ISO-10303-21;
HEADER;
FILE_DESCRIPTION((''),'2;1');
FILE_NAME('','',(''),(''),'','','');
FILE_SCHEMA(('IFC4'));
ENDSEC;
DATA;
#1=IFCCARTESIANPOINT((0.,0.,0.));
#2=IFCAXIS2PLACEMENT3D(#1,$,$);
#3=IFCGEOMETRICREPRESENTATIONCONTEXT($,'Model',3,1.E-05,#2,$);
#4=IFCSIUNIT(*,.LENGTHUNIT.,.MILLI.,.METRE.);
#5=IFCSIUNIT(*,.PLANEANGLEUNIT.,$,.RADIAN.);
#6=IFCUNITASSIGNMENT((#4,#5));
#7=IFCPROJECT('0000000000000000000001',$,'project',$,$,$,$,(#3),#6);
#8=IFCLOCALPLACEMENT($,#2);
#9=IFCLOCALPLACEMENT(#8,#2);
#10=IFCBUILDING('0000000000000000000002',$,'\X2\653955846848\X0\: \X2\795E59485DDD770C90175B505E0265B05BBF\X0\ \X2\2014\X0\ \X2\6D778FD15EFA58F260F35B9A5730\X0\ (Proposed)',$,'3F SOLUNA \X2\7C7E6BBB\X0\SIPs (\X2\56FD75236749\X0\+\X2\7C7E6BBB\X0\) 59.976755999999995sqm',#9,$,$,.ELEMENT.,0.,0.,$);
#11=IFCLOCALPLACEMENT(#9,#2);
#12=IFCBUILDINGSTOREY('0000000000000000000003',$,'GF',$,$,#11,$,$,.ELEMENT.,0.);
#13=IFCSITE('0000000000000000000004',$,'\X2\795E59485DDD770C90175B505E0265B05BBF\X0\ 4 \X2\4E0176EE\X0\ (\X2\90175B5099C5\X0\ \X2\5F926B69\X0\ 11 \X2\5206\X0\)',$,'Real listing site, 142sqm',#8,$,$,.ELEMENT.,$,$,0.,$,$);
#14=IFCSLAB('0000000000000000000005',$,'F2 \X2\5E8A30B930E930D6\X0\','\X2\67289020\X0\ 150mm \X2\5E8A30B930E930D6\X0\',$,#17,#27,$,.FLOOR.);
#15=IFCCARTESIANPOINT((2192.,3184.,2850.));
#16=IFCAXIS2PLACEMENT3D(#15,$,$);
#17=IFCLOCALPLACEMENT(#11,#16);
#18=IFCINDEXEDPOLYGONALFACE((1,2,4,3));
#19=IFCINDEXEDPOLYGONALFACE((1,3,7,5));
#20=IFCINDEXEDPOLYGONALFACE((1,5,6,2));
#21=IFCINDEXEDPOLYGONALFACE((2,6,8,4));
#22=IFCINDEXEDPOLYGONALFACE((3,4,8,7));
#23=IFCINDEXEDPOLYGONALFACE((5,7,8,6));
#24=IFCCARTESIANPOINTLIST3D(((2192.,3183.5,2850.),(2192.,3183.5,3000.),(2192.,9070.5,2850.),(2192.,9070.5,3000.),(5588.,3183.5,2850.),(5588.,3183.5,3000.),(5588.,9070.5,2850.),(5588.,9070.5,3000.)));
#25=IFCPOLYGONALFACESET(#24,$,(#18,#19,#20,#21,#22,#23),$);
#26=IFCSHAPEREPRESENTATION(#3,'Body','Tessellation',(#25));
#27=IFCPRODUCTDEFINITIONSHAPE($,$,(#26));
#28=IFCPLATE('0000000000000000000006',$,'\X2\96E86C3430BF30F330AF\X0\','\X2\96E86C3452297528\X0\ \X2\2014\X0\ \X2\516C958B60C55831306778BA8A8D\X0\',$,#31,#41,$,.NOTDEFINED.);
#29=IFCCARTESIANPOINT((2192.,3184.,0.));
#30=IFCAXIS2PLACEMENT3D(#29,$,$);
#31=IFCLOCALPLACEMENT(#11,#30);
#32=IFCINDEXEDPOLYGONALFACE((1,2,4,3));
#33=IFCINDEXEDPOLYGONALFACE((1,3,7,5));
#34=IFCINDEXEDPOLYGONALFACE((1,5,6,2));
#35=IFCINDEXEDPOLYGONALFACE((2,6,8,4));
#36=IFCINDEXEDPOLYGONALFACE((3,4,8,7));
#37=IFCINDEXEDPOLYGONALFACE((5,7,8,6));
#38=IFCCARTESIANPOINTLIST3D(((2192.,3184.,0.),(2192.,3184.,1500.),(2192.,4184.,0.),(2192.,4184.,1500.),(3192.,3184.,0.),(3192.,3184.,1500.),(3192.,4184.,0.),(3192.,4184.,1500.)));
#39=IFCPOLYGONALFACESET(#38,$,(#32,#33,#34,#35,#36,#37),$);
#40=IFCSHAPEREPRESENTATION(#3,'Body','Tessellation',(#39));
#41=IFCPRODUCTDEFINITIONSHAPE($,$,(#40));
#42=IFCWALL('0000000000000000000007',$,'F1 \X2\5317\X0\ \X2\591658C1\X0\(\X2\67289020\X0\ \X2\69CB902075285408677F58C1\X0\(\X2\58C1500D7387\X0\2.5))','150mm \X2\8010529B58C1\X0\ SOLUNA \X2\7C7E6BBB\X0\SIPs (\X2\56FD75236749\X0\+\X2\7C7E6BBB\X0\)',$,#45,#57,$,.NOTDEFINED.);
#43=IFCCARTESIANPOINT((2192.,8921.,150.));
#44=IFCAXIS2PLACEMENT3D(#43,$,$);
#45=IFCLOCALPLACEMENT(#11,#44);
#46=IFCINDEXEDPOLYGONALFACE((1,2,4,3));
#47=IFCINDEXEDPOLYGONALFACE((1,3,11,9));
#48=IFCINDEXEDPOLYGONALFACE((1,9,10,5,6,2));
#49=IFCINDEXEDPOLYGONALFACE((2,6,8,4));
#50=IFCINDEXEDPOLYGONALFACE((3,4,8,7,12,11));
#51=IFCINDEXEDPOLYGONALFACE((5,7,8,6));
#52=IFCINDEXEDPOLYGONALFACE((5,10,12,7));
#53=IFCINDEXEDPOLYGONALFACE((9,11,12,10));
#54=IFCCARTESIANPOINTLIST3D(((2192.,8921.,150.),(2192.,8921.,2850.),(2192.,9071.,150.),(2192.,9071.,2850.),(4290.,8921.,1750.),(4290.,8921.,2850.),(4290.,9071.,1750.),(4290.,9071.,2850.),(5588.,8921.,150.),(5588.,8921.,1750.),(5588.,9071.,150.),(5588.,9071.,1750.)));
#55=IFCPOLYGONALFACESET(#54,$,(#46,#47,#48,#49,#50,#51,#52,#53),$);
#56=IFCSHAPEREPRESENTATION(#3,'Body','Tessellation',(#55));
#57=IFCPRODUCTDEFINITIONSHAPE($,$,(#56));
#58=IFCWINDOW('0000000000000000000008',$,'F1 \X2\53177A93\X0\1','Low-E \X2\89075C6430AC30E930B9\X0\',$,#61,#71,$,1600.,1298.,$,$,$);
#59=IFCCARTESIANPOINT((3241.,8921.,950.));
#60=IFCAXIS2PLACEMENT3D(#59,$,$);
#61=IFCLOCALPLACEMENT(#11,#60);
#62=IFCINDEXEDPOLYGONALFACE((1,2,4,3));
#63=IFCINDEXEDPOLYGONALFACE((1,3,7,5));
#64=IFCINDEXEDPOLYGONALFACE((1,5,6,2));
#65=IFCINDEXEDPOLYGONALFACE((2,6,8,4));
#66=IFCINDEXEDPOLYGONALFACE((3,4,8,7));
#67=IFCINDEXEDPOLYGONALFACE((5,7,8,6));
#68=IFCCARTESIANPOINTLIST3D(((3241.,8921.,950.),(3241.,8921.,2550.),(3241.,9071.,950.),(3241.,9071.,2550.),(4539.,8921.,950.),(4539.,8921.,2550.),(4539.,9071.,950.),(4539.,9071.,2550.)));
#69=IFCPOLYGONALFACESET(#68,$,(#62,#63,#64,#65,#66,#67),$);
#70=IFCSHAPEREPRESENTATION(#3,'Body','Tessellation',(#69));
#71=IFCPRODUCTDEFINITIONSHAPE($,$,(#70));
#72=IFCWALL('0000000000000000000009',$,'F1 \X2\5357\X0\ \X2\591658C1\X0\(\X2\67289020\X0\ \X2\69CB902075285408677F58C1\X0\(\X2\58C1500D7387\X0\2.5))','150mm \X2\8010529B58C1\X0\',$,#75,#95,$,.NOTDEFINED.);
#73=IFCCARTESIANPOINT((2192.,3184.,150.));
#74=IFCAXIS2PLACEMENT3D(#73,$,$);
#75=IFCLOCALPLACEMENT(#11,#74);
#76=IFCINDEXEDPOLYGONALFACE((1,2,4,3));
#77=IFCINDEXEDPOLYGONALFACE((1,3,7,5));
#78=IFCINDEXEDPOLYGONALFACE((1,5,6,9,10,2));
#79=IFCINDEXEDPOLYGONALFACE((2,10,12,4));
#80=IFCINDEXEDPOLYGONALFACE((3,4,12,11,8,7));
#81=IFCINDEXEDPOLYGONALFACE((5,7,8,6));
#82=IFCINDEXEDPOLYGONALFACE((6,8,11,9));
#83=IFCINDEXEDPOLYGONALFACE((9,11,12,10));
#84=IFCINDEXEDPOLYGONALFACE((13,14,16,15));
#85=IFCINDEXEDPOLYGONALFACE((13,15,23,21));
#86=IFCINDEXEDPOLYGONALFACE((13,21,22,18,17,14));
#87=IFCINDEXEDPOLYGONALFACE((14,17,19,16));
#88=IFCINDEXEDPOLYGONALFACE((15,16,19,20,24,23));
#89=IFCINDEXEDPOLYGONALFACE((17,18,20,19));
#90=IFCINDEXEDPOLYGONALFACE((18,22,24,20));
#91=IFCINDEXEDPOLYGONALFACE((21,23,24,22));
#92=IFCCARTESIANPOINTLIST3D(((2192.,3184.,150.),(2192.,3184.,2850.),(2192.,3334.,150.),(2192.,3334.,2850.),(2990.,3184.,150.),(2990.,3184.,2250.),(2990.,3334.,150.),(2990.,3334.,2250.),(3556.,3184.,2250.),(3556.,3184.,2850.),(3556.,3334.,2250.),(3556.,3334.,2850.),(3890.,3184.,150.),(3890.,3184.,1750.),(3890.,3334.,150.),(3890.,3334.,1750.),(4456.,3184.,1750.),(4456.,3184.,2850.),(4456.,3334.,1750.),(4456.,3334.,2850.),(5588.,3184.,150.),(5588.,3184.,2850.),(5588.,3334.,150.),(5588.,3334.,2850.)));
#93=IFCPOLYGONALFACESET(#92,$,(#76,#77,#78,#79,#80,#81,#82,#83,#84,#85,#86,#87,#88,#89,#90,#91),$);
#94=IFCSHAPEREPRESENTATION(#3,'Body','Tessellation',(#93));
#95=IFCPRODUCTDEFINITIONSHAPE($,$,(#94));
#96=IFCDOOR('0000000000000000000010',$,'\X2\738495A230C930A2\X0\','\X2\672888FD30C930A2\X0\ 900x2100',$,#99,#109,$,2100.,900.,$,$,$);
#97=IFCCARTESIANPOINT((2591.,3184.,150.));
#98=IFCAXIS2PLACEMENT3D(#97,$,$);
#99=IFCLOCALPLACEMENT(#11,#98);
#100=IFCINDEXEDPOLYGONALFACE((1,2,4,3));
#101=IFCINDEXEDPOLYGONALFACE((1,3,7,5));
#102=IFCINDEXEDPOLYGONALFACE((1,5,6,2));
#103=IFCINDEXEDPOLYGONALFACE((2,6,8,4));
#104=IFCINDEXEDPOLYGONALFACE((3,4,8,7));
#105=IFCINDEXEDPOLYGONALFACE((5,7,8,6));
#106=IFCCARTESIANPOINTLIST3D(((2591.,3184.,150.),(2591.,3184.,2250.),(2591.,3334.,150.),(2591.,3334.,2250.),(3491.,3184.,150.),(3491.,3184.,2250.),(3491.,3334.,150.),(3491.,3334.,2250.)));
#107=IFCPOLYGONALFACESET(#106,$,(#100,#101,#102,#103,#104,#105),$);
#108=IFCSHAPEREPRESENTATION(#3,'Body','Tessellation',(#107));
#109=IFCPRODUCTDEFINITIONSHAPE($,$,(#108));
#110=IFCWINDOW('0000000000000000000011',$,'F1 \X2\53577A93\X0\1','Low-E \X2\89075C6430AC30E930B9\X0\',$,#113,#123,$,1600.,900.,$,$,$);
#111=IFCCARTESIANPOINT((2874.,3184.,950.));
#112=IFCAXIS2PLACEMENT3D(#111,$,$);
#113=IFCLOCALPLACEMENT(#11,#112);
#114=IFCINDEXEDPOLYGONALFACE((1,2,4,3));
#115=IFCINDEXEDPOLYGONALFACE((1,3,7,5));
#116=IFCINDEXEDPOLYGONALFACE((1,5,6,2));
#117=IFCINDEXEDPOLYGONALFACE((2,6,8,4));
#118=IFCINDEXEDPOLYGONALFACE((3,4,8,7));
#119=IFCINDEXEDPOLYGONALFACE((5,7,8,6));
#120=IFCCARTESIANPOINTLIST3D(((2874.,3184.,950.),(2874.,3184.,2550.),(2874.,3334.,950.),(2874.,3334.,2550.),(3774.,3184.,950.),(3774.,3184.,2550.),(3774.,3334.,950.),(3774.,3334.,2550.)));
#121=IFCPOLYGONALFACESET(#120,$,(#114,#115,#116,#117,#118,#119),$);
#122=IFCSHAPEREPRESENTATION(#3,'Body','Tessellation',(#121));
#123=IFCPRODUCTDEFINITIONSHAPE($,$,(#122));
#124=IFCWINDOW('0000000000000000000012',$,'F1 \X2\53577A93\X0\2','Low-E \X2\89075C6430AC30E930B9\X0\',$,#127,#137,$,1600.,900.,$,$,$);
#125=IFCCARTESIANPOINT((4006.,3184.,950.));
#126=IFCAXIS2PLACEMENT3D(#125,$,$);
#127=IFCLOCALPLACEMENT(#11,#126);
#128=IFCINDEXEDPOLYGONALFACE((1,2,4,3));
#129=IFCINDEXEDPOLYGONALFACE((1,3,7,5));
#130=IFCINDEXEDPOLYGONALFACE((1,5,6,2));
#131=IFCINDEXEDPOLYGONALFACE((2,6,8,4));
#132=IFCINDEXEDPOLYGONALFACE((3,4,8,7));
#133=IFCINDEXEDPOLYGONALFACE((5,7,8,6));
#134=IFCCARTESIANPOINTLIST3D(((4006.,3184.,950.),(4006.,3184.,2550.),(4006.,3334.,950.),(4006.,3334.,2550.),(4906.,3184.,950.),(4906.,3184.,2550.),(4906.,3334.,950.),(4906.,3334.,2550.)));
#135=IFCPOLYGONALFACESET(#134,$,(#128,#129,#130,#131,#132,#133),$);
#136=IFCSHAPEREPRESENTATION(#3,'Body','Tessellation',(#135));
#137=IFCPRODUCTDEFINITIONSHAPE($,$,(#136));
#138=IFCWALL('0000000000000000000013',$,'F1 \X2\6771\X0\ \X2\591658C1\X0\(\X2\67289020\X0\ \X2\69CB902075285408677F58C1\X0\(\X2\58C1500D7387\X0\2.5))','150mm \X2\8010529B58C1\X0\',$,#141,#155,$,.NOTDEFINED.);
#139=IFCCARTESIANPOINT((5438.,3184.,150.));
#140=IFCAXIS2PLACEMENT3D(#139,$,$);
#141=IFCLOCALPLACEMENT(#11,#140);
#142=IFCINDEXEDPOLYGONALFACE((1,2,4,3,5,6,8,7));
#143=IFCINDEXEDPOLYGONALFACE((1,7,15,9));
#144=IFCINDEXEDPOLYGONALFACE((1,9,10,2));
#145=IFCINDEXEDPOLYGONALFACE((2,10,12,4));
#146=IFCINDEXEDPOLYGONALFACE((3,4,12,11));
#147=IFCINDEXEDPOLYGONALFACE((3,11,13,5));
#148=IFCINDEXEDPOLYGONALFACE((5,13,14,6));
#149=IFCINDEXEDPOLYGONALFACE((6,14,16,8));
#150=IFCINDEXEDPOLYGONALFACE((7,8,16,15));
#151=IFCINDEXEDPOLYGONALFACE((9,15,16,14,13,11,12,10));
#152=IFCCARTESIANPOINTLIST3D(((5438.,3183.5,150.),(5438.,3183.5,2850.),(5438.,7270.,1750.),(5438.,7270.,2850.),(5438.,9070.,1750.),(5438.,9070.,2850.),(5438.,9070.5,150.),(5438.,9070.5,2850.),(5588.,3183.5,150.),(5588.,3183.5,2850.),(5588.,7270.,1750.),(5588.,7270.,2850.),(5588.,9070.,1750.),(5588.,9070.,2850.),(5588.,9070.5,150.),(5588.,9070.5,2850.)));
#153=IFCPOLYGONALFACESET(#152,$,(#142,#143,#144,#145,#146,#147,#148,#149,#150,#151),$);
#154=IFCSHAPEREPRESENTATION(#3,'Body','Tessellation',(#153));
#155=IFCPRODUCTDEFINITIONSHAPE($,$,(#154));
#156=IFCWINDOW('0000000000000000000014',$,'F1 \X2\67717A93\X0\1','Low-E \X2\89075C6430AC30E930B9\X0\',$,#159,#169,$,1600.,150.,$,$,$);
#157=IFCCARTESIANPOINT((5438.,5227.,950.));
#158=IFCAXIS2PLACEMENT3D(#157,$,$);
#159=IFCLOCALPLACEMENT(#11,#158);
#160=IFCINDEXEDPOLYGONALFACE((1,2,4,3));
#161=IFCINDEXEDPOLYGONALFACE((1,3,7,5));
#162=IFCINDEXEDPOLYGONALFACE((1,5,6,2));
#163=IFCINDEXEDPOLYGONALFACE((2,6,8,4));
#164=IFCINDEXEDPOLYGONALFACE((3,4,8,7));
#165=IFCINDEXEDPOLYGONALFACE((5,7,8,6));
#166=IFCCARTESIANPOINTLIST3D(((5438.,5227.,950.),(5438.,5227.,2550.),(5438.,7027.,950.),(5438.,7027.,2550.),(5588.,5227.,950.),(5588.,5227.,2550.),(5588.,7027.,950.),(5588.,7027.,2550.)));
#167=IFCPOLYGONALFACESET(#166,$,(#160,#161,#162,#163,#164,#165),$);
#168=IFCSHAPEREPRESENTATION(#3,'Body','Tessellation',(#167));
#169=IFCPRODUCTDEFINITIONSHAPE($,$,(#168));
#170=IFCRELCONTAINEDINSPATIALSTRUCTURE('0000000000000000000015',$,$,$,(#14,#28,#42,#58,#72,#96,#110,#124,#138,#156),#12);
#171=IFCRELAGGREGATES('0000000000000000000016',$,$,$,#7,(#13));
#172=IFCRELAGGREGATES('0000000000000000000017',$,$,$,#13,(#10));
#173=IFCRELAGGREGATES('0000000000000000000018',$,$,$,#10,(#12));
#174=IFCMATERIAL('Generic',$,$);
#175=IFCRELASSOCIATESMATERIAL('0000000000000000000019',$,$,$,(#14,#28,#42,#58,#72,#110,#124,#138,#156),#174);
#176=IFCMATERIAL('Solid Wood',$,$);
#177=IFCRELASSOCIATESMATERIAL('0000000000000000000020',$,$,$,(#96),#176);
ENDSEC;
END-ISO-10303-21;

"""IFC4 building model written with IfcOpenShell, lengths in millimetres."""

from ifc_helpers import new_model, si_unit, frame, frame_2d, origin, place, context, project, spatial, rectangle, extrude, material, element, fill, save


model = new_model("IFC4")

# Units and contexts
model_context = context("Model", 3, precision=1e-05, world=origin())
ifc_project = project(units=[si_unit("LENGTHUNIT", "METRE", prefix="MILLI"), si_unit("PLANEANGLEUNIT", "RADIAN")], contexts=[model_context])

# Site, building, storey
site_placement = place(None, origin())
site = spatial("IfcSite", under=ifc_project, at=site_placement, Name="神奈川県逗子市新宿 4 丁目 (逗子駅 徒歩 11 分)", ObjectType="Real listing site, 142sqm", CompositionType="ELEMENT", RefElevation=0.0)
building_placement = place(site_placement, origin())
building = spatial("IfcBuilding", under=site, at=building_placement, Name="改善案: 神奈川県逗子市新宿 — 海近建売想定地 (Proposed)", ObjectType="3F SOLUNA 籾殻SIPs (国産杉+籾殻) 59.976755999999995sqm", CompositionType="ELEMENT", ElevationOfRefHeight=0.0, ElevationOfTerrain=0.0)
storey_placement = place(building_placement, origin())
storey = spatial("IfcBuildingStorey", under=building, at=storey_placement, Name="GF", CompositionType="ELEMENT", Elevation=0.0)

# Slab
ifc_material_1 = material(Name="Generic")
slab_1_placement = place(storey_placement, frame((2192.0, 3184.0, 2850.0)))
element("IfcSlab", 1, at=slab_1_placement, inside=storey, material=ifc_material_1, Name="F2 床スラブ", Description="木造 150mm 床スラブ", PredefinedType="FLOOR", context=model_context, shape_type="SweptSolid", body=[
    extrude(rectangle(XDim=3396.0, YDim=5887.0, at=frame_2d((1698.0, 2943.0))), frame((2192.0, 3184.0, 2850.0)), (0.0, 0.0, 1.0), 150.0),
])

# Plate
plate_placement = place(storey_placement, frame((2192.0, 3184.0, 0.0)))
element("IfcPlate", 2, at=plate_placement, inside=storey, material=ifc_material_1, Name="雨水タンク", Description="雨水利用 — 公開情報で確認", PredefinedType="NOTDEFINED", context=model_context, shape_type="SweptSolid", body=[
    extrude(rectangle(XDim=1000.0, YDim=1000.0, at=frame_2d((500.0, 500.0))), frame((2192.0, 3184.0, 0.0)), (0.0, 0.0, 1.0), 1500.0),
])

# Wall, opening, window
wall_1_placement = place(storey_placement, frame((2192.0, 8921.0, 150.0)))
wall_1 = element("IfcWall", 3, at=wall_1_placement, inside=storey, material=ifc_material_1, Name="F1 北 外壁(木造 構造用合板壁(壁倍率2.5))", Description="150mm 耐力壁 SOLUNA 籾殻SIPs (国産杉+籾殻)", PredefinedType="NOTDEFINED", context=model_context, shape_type="SweptSolid", body=[
    extrude(rectangle(XDim=3396.0, YDim=150.0, at=frame_2d((1698.0, 75.0))), frame((2192.0, 8921.0, 150.0)), (0.0, 0.0, 1.0), 2700.0),
])
opening_1_placement = place(storey_placement, frame((3241.0, 8921.0, 950.0)))
opening_1 = element("IfcOpeningElement", 4, at=opening_1_placement, cuts=wall_1, PredefinedType="NOTDEFINED", context=model_context, shape_type="SweptSolid", body=[
    extrude(rectangle(XDim=1298.0, YDim=150.0, at=frame_2d((649.0, 75.0))), frame((3241.0, 8921.0, 950.0)), (0.0, 0.0, 1.0), 1600.0),
])
window_1_placement = place(storey_placement, frame((3241.0, 8921.0, 950.0)))
window_1 = element("IfcWindow", 5, at=window_1_placement, inside=storey, material=ifc_material_1, Name="F1 北窓1", Description="Low-E 複層ガラス", OverallHeight=1600.0, OverallWidth=1298.0, context=model_context, shape_type="SweptSolid", body=[
    extrude(rectangle(XDim=1298.0, YDim=150.0, at=frame_2d((649.0, 75.0))), frame((3241.0, 8921.0, 950.0)), (0.0, 0.0, 1.0), 1600.0),
])
fill(opening_1, window_1)

# Wall, openings, door, windows
wall_2_placement = place(storey_placement, frame((2192.0, 3184.0, 150.0)))
wall_2 = element("IfcWall", 6, at=wall_2_placement, inside=storey, material=ifc_material_1, Name="F1 南 外壁(木造 構造用合板壁(壁倍率2.5))", Description="150mm 耐力壁", PredefinedType="NOTDEFINED", context=model_context, shape_type="SweptSolid", body=[
    extrude(rectangle(XDim=3396.0, YDim=150.0, at=frame_2d((1698.0, 75.0))), frame((2192.0, 3184.0, 150.0)), (0.0, 0.0, 1.0), 2700.0),
])
opening_2_placement = place(storey_placement, frame((2591.0, 3184.0, 150.0)))
opening_2 = element("IfcOpeningElement", 7, at=opening_2_placement, cuts=wall_2, PredefinedType="NOTDEFINED", context=model_context, shape_type="SweptSolid", body=[
    extrude(rectangle(XDim=900.0, YDim=150.0, at=frame_2d((450.0, 75.0))), frame((2591.0, 3184.0, 150.0)), (0.0, 0.0, 1.0), 2100.0),
])
opening_3_placement = place(storey_placement, frame((2874.0, 3184.0, 950.0)))
opening_3 = element("IfcOpeningElement", 8, at=opening_3_placement, cuts=wall_2, PredefinedType="NOTDEFINED", context=model_context, shape_type="SweptSolid", body=[
    extrude(rectangle(XDim=900.0, YDim=150.0, at=frame_2d((450.0, 75.0))), frame((2874.0, 3184.0, 950.0)), (0.0, 0.0, 1.0), 1600.0),
])
opening_4_placement = place(storey_placement, frame((4006.0, 3184.0, 950.0)))
opening_4 = element("IfcOpeningElement", 9, at=opening_4_placement, cuts=wall_2, PredefinedType="NOTDEFINED", context=model_context, shape_type="SweptSolid", body=[
    extrude(rectangle(XDim=900.0, YDim=150.0, at=frame_2d((450.0, 75.0))), frame((4006.0, 3184.0, 950.0)), (0.0, 0.0, 1.0), 1600.0),
])
ifc_material_2 = material(Name="Solid Wood")
door_placement = place(storey_placement, frame((2591.0, 3184.0, 150.0)))
door = element("IfcDoor", 10, at=door_placement, inside=storey, material=ifc_material_2, Name="玄関ドア", Description="木製ドア 900x2100", OverallHeight=2100.0, OverallWidth=900.0, context=model_context, shape_type="SweptSolid", body=[
    extrude(rectangle(XDim=900.0, YDim=150.0, at=frame_2d((450.0, 75.0))), frame((2591.0, 3184.0, 150.0)), (0.0, 0.0, 1.0), 2100.0),
])
fill(opening_2, door)
window_2_placement = place(storey_placement, frame((2874.0, 3184.0, 950.0)))
window_2 = element("IfcWindow", 11, at=window_2_placement, inside=storey, material=ifc_material_1, Name="F1 南窓1", Description="Low-E 複層ガラス", OverallHeight=1600.0, OverallWidth=900.0, context=model_context, shape_type="SweptSolid", body=[
    extrude(rectangle(XDim=900.0, YDim=150.0, at=frame_2d((450.0, 75.0))), frame((2874.0, 3184.0, 950.0)), (0.0, 0.0, 1.0), 1600.0),
])
fill(opening_3, window_2)
window_3_placement = place(storey_placement, frame((4006.0, 3184.0, 950.0)))
window_3 = element("IfcWindow", 12, at=window_3_placement, inside=storey, material=ifc_material_1, Name="F1 南窓2", Description="Low-E 複層ガラス", OverallHeight=1600.0, OverallWidth=900.0, context=model_context, shape_type="SweptSolid", body=[
    extrude(rectangle(XDim=900.0, YDim=150.0, at=frame_2d((450.0, 75.0))), frame((4006.0, 3184.0, 950.0)), (0.0, 0.0, 1.0), 1600.0),
])
fill(opening_4, window_3)

# Wall, opening, window
wall_3_placement = place(storey_placement, frame((5438.0, 3184.0, 150.0)))
wall_3 = element("IfcWall", 13, at=wall_3_placement, inside=storey, material=ifc_material_1, Name="F1 東 外壁(木造 構造用合板壁(壁倍率2.5))", Description="150mm 耐力壁", PredefinedType="NOTDEFINED", context=model_context, shape_type="SweptSolid", body=[
    extrude(rectangle(XDim=150.0, YDim=5887.0, at=frame_2d((75.0, 2943.0))), frame((5438.0, 3184.0, 150.0)), (0.0, 0.0, 1.0), 2700.0),
])
opening_5_placement = place(storey_placement, frame((5438.0, 5227.0, 950.0)))
opening_5 = element("IfcOpeningElement", 14, at=opening_5_placement, cuts=wall_3, PredefinedType="NOTDEFINED", context=model_context, shape_type="SweptSolid", body=[
    extrude(rectangle(XDim=150.0, YDim=1800.0, at=frame_2d((75.0, 900.0))), frame((5438.0, 5227.0, 950.0)), (0.0, 0.0, 1.0), 1600.0),
])
window_4_placement = place(storey_placement, frame((5438.0, 5227.0, 950.0)))
window_4 = element("IfcWindow", 15, at=window_4_placement, inside=storey, material=ifc_material_1, Name="F1 東窓1", Description="Low-E 複層ガラス", OverallHeight=1600.0, OverallWidth=150.0, context=model_context, shape_type="SweptSolid", body=[
    extrude(rectangle(XDim=150.0, YDim=1800.0, at=frame_2d((75.0, 900.0))), frame((5438.0, 5227.0, 950.0)), (0.0, 0.0, 1.0), 1600.0),
])
fill(opening_5, window_4)

save(model, "model.ifc")
